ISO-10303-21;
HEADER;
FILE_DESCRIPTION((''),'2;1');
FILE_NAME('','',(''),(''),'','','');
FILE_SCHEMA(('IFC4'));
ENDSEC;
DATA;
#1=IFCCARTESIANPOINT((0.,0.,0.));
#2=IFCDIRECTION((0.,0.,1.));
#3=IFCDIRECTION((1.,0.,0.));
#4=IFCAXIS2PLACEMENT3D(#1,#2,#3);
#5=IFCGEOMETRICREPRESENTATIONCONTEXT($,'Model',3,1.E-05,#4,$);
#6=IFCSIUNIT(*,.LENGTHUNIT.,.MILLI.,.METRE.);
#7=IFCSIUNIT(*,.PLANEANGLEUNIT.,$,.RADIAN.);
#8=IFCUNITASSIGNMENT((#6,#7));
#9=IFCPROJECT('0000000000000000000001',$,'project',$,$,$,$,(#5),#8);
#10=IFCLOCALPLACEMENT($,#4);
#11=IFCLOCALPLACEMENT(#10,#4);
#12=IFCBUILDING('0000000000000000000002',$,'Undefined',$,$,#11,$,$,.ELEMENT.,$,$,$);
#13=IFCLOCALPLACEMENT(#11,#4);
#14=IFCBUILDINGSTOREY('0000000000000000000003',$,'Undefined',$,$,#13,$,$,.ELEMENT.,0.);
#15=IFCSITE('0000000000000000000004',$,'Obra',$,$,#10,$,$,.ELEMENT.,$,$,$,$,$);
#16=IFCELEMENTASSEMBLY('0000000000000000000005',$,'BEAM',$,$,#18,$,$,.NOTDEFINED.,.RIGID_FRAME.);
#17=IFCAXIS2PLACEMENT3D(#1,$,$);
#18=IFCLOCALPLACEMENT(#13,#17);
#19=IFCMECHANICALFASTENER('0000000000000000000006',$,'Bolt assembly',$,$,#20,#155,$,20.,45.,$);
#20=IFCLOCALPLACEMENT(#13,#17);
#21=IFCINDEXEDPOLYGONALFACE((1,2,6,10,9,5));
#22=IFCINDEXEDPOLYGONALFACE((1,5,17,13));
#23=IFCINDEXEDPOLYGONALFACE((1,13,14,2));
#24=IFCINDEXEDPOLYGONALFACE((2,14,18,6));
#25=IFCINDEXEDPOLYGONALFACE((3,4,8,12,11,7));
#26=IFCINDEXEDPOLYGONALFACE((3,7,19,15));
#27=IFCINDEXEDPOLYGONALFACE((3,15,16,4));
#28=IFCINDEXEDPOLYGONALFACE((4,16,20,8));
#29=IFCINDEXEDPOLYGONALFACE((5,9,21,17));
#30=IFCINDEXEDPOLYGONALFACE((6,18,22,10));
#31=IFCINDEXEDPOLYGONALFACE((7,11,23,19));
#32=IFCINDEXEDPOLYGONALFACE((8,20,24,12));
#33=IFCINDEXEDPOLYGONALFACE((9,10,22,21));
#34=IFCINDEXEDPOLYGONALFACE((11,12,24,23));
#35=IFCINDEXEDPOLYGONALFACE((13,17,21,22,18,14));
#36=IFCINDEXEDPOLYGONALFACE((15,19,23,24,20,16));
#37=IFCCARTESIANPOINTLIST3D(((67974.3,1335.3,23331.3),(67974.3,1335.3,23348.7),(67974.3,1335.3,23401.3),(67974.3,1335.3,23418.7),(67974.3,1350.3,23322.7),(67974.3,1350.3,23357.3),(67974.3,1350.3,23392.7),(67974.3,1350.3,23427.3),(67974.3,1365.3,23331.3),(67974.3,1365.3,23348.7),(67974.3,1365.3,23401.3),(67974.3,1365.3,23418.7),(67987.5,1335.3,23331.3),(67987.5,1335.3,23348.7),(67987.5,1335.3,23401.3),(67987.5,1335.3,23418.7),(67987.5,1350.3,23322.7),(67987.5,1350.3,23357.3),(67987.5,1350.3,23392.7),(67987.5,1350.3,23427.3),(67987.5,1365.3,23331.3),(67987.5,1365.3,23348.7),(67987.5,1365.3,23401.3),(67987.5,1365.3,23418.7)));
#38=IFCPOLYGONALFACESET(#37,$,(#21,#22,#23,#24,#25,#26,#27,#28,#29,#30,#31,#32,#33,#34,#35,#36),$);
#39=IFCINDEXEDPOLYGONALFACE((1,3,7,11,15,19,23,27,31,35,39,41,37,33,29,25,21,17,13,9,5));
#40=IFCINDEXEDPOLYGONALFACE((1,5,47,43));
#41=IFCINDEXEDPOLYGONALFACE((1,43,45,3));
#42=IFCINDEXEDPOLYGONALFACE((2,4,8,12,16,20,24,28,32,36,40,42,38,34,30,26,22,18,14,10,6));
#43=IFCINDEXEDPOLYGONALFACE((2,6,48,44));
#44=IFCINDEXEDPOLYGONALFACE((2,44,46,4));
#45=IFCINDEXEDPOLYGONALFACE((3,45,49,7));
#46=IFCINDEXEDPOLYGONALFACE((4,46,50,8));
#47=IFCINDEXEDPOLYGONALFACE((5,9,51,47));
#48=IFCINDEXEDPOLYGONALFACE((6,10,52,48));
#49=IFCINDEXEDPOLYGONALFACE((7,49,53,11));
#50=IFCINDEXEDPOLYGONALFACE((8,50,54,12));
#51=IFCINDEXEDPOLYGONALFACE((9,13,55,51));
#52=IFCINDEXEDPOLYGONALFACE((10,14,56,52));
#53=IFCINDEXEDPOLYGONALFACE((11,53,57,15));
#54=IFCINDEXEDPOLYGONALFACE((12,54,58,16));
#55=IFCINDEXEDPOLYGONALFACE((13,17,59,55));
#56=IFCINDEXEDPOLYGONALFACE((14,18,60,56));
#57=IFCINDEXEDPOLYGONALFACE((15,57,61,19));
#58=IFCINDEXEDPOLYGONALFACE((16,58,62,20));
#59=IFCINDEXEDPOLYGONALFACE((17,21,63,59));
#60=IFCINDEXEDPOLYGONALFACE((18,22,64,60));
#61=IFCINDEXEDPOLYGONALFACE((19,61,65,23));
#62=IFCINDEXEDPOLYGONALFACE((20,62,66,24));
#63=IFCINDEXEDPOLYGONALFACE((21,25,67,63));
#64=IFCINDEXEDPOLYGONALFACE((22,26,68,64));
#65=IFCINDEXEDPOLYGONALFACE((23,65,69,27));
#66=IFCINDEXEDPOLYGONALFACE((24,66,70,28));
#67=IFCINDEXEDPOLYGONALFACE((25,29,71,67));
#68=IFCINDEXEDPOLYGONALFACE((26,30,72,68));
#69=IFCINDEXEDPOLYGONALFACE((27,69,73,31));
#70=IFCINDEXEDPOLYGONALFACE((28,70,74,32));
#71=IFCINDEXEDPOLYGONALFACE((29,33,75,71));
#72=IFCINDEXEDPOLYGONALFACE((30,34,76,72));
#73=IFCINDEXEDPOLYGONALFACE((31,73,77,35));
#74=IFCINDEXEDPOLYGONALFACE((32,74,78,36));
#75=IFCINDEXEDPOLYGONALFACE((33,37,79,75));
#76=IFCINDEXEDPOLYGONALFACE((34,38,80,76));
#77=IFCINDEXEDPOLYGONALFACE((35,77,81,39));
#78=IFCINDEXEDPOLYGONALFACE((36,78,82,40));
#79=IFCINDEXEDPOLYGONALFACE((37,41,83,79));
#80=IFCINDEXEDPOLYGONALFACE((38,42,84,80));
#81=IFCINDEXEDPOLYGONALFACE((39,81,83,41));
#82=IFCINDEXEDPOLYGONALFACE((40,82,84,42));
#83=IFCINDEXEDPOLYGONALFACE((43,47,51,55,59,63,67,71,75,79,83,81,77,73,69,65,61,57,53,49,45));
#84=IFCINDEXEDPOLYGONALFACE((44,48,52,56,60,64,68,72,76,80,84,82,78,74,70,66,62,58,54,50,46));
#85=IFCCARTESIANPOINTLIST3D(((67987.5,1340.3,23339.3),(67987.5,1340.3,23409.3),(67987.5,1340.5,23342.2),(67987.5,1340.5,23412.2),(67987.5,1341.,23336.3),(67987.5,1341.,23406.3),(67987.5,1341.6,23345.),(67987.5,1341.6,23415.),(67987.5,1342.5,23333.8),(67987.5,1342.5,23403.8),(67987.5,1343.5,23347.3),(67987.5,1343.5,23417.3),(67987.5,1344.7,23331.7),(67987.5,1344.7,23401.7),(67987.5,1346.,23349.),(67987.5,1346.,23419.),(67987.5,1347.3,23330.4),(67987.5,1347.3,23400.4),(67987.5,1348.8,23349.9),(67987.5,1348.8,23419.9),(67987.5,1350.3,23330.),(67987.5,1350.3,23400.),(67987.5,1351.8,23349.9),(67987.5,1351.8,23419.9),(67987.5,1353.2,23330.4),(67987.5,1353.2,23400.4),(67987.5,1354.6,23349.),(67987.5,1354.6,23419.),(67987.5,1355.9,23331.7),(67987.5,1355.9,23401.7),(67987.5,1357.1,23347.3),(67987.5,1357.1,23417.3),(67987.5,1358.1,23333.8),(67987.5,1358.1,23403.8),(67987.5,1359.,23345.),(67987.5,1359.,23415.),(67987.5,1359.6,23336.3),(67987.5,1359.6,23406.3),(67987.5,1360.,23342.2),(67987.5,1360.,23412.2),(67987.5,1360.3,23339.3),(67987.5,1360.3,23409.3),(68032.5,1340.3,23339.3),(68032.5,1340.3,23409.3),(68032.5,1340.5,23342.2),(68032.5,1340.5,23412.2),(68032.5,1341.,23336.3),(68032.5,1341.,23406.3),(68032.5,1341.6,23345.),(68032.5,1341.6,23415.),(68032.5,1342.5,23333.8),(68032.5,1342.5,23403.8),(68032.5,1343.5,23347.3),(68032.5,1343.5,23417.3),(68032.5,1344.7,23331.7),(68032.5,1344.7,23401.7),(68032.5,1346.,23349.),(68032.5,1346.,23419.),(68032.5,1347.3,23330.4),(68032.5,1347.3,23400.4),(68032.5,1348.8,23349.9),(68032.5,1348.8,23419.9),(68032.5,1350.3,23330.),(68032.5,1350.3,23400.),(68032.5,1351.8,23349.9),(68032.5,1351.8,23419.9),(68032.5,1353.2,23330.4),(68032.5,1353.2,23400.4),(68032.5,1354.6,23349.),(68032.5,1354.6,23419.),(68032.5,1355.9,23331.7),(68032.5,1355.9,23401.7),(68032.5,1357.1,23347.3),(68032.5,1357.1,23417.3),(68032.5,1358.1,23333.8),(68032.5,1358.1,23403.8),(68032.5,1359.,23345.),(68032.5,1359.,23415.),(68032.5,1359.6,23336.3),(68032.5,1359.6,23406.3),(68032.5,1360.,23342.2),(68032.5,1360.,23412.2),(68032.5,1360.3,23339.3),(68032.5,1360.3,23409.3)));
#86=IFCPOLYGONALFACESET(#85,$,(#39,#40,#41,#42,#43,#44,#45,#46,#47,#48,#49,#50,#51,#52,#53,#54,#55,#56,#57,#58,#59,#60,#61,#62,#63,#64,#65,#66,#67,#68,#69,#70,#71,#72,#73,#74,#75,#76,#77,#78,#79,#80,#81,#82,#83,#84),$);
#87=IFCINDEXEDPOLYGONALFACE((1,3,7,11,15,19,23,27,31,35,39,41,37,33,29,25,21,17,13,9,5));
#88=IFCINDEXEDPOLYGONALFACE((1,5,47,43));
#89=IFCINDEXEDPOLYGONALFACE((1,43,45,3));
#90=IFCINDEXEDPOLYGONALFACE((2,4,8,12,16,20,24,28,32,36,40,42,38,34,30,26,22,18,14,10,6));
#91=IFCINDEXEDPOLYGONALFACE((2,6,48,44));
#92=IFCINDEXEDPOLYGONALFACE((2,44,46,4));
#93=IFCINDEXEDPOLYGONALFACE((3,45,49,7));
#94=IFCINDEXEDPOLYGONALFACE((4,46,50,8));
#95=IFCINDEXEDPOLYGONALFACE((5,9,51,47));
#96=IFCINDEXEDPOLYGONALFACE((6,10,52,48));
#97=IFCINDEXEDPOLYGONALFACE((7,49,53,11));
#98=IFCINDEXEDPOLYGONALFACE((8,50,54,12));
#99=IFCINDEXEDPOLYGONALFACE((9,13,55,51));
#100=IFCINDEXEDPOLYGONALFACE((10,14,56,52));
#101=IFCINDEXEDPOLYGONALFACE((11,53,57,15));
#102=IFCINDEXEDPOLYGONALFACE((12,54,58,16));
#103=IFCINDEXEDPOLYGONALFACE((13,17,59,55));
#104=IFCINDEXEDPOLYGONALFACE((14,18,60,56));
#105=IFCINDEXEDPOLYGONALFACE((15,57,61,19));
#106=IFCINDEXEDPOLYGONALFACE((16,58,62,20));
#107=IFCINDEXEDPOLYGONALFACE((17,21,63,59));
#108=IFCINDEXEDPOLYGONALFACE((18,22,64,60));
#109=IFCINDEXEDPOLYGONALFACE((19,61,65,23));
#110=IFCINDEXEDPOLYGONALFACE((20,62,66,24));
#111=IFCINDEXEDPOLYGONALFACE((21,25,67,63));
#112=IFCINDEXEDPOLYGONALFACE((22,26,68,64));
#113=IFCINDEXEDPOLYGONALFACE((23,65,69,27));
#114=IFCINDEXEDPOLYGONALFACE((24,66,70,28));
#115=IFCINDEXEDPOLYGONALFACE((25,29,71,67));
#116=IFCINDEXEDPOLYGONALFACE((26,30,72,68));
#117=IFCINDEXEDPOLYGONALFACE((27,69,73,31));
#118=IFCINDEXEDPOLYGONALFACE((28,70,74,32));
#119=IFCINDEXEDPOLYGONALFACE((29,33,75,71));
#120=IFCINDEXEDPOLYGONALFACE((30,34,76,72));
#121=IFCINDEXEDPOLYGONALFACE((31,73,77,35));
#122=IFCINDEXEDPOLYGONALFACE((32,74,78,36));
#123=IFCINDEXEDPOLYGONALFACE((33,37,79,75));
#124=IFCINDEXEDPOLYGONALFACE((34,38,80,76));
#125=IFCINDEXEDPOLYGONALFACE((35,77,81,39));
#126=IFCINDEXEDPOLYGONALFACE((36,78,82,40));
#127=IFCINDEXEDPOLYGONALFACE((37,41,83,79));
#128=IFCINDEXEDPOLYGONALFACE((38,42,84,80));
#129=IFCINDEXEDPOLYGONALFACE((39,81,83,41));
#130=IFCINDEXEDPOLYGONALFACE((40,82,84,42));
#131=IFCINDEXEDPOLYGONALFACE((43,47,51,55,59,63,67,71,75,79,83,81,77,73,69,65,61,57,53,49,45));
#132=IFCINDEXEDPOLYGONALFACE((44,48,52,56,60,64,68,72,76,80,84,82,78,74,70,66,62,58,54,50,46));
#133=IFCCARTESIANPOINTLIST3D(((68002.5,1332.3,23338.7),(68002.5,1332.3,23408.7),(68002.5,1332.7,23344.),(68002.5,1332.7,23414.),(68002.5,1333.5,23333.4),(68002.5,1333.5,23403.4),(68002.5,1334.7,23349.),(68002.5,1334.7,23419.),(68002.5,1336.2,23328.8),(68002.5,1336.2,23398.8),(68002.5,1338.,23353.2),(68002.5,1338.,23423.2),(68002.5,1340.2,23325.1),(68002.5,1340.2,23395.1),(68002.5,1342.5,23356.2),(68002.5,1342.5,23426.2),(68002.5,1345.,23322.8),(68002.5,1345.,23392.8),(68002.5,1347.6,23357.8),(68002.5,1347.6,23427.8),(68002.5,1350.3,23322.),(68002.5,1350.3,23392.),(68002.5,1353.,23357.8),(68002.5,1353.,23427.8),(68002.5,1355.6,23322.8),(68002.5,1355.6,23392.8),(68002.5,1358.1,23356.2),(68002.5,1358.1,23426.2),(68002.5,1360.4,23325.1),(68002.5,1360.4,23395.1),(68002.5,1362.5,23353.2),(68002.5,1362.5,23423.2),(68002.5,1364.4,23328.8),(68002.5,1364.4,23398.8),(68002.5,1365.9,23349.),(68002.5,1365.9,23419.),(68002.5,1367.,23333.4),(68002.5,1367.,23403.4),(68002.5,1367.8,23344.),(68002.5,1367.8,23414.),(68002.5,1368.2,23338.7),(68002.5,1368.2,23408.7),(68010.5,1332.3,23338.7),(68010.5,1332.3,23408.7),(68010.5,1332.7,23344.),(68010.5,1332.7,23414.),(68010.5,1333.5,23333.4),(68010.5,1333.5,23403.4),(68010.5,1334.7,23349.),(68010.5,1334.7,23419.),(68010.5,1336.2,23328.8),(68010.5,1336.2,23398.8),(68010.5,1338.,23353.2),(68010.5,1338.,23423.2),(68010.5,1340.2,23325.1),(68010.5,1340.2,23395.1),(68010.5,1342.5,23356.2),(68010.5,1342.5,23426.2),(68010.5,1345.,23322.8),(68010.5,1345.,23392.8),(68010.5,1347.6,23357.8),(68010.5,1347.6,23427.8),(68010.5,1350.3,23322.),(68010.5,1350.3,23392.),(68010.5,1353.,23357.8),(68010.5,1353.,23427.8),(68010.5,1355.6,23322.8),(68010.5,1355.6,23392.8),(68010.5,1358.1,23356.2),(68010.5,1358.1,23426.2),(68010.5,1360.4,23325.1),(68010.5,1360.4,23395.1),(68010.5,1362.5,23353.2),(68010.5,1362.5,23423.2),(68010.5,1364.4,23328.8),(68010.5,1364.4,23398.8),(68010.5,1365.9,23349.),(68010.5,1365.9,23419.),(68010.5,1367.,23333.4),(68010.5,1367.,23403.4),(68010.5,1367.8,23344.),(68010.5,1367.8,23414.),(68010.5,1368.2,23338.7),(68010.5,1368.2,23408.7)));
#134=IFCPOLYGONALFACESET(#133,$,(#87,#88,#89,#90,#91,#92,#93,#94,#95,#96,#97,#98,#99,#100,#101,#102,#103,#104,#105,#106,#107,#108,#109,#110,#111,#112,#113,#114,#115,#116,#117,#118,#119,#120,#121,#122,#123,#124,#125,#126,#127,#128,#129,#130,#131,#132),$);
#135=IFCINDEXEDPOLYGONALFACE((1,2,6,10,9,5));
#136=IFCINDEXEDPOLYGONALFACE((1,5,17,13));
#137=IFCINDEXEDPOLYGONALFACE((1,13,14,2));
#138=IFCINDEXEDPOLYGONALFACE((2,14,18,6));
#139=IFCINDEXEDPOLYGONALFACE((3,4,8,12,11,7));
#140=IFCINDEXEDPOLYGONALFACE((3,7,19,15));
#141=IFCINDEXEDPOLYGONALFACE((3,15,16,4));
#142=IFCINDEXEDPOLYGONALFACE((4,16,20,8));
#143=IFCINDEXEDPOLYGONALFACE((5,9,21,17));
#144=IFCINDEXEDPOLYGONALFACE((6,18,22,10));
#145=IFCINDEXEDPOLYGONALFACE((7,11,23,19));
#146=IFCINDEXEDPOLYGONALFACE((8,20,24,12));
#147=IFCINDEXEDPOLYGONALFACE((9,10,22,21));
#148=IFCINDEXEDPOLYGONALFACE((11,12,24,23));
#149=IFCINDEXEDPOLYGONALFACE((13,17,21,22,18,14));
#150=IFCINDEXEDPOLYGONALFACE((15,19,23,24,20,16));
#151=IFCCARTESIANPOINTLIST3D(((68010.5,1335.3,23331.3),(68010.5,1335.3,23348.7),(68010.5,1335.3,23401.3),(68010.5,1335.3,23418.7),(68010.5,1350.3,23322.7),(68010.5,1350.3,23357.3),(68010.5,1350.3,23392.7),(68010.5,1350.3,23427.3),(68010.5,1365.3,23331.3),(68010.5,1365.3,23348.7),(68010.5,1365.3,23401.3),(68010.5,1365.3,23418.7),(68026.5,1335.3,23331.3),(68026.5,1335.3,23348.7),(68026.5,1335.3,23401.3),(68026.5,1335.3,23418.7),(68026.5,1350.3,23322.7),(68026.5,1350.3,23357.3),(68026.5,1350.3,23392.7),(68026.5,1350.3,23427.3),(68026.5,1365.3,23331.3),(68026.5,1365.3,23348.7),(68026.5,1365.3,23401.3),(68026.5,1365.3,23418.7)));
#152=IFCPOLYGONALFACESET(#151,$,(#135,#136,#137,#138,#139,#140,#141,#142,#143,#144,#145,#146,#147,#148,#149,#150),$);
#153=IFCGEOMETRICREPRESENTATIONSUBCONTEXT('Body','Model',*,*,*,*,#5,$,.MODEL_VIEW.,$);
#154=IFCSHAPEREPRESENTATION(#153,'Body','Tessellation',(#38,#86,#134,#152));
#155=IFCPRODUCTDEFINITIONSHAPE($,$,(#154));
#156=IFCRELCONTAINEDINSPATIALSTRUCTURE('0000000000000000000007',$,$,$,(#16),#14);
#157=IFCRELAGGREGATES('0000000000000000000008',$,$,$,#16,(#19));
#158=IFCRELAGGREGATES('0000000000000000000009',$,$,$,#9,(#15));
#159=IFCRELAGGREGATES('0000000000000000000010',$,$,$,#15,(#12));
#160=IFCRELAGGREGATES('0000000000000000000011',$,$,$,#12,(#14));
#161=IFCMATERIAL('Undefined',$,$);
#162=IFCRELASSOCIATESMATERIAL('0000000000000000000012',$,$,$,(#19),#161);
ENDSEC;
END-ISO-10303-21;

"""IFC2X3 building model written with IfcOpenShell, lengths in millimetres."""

from ifc_helpers import new_model, si_unit, frame, origin_with_axes, origin_2d_with_axis, place, context, subcontext, project, spatial, polyline, circle, outline, extrude, source, transform, mapped, material, element, aggregate, save


model = new_model("IFC2X3")

# Units and contexts
model_context = context("Model", 3, precision=1e-05, world=origin_with_axes())
body_context = subcontext(model_context, "Body", "Model", "MODEL_VIEW")
ifc_project = project(units=[si_unit("LENGTHUNIT", "METRE", prefix="MILLI"), si_unit("PLANEANGLEUNIT", "RADIAN")], contexts=[model_context])

# Site, building, storey
site_placement = place(None, origin_with_axes())
site = spatial("IfcSite", under=ifc_project, at=site_placement, Name="Obra", CompositionType="ELEMENT")
building_placement = place(site_placement, origin_with_axes())
building = spatial("IfcBuilding", under=site, at=building_placement, Name="Undefined", CompositionType="ELEMENT")
storey_placement = place(building_placement, origin_with_axes())
storey = spatial("IfcBuildingStorey", under=building, at=storey_placement, Name="Undefined", CompositionType="ELEMENT", Elevation=0.0)

# Shared definitions
ifc_material_1 = material(Name="Undefined")

# Element assembly
assembly_1_placement = place(storey_placement, origin_with_axes())
assembly_1 = element("IfcElementAssembly", 1, at=assembly_1_placement, inside=storey, Name="BEAM", AssemblyPlace="NOTDEFINED", PredefinedType="RIGID_FRAME")

# Mechanical fastener
shared_shape_1 = source(origin_with_axes(), body_context, "Body", "SweptSolid", [
    extrude(outline(polyline([(17.3, 0.0), (8.7, 15.0), (-8.7, 15.0), (-17.3, 0.0), (-8.7, -15.0), (8.7, -15.0), (17.3, 0.0)])), frame((0.0, -25.7, 0.0), z_axis=(0.0, 1.0, 0.0), x_axis=(1.0, 0.0, 0.0)), (0.0, 0.0, 1.0), 13.2),
    extrude(circle(Radius=10.0, at=origin_2d_with_axis()), frame((0.0, -12.5, 0.0), z_axis=(0.0, 1.0, 0.0), x_axis=(1.0, 0.0, 0.0)), (0.0, 0.0, 1.0), 45.0),
    extrude(circle(Radius=18.0, at=origin_2d_with_axis()), frame((0.0, 2.5, 0.0), z_axis=(0.0, 1.0, 0.0), x_axis=(1.0, 0.0, 0.0)), (0.0, 0.0, 1.0), 8.0),
    extrude(outline(polyline([(17.3, 0.0), (8.7, 15.0), (-8.7, 15.0), (-17.3, 0.0), (-8.7, -15.0), (8.7, -15.0), (17.3, 0.0)])), frame((0.0, 10.5, 0.0), z_axis=(0.0, 1.0, 0.0), x_axis=(1.0, 0.0, 0.0)), (0.0, 0.0, 1.0), 16.0),
])
mechanical_fastener_1_placement = place(assembly_1_placement, frame((68000.0, 1390.3, 23455.0), z_axis=(0.0, -1.0, 0.0), x_axis=(0.0, 0.0, -1.0)))
mechanical_fastener_1 = element("IfcMechanicalFastener", 2, at=mechanical_fastener_1_placement, material=ifc_material_1, Name="Bolt assembly", NominalDiameter=20.0, NominalLength=45.0, context=body_context, shape_type="MappedRepresentation", body=[
    mapped(shared_shape_1, transform((45.0, 0.0, 40.0))),
    mapped(shared_shape_1, transform((115.0, 0.0, 40.0))),
])
aggregate(assembly_1, [mechanical_fastener_1])

save(model, "model.ifc")
